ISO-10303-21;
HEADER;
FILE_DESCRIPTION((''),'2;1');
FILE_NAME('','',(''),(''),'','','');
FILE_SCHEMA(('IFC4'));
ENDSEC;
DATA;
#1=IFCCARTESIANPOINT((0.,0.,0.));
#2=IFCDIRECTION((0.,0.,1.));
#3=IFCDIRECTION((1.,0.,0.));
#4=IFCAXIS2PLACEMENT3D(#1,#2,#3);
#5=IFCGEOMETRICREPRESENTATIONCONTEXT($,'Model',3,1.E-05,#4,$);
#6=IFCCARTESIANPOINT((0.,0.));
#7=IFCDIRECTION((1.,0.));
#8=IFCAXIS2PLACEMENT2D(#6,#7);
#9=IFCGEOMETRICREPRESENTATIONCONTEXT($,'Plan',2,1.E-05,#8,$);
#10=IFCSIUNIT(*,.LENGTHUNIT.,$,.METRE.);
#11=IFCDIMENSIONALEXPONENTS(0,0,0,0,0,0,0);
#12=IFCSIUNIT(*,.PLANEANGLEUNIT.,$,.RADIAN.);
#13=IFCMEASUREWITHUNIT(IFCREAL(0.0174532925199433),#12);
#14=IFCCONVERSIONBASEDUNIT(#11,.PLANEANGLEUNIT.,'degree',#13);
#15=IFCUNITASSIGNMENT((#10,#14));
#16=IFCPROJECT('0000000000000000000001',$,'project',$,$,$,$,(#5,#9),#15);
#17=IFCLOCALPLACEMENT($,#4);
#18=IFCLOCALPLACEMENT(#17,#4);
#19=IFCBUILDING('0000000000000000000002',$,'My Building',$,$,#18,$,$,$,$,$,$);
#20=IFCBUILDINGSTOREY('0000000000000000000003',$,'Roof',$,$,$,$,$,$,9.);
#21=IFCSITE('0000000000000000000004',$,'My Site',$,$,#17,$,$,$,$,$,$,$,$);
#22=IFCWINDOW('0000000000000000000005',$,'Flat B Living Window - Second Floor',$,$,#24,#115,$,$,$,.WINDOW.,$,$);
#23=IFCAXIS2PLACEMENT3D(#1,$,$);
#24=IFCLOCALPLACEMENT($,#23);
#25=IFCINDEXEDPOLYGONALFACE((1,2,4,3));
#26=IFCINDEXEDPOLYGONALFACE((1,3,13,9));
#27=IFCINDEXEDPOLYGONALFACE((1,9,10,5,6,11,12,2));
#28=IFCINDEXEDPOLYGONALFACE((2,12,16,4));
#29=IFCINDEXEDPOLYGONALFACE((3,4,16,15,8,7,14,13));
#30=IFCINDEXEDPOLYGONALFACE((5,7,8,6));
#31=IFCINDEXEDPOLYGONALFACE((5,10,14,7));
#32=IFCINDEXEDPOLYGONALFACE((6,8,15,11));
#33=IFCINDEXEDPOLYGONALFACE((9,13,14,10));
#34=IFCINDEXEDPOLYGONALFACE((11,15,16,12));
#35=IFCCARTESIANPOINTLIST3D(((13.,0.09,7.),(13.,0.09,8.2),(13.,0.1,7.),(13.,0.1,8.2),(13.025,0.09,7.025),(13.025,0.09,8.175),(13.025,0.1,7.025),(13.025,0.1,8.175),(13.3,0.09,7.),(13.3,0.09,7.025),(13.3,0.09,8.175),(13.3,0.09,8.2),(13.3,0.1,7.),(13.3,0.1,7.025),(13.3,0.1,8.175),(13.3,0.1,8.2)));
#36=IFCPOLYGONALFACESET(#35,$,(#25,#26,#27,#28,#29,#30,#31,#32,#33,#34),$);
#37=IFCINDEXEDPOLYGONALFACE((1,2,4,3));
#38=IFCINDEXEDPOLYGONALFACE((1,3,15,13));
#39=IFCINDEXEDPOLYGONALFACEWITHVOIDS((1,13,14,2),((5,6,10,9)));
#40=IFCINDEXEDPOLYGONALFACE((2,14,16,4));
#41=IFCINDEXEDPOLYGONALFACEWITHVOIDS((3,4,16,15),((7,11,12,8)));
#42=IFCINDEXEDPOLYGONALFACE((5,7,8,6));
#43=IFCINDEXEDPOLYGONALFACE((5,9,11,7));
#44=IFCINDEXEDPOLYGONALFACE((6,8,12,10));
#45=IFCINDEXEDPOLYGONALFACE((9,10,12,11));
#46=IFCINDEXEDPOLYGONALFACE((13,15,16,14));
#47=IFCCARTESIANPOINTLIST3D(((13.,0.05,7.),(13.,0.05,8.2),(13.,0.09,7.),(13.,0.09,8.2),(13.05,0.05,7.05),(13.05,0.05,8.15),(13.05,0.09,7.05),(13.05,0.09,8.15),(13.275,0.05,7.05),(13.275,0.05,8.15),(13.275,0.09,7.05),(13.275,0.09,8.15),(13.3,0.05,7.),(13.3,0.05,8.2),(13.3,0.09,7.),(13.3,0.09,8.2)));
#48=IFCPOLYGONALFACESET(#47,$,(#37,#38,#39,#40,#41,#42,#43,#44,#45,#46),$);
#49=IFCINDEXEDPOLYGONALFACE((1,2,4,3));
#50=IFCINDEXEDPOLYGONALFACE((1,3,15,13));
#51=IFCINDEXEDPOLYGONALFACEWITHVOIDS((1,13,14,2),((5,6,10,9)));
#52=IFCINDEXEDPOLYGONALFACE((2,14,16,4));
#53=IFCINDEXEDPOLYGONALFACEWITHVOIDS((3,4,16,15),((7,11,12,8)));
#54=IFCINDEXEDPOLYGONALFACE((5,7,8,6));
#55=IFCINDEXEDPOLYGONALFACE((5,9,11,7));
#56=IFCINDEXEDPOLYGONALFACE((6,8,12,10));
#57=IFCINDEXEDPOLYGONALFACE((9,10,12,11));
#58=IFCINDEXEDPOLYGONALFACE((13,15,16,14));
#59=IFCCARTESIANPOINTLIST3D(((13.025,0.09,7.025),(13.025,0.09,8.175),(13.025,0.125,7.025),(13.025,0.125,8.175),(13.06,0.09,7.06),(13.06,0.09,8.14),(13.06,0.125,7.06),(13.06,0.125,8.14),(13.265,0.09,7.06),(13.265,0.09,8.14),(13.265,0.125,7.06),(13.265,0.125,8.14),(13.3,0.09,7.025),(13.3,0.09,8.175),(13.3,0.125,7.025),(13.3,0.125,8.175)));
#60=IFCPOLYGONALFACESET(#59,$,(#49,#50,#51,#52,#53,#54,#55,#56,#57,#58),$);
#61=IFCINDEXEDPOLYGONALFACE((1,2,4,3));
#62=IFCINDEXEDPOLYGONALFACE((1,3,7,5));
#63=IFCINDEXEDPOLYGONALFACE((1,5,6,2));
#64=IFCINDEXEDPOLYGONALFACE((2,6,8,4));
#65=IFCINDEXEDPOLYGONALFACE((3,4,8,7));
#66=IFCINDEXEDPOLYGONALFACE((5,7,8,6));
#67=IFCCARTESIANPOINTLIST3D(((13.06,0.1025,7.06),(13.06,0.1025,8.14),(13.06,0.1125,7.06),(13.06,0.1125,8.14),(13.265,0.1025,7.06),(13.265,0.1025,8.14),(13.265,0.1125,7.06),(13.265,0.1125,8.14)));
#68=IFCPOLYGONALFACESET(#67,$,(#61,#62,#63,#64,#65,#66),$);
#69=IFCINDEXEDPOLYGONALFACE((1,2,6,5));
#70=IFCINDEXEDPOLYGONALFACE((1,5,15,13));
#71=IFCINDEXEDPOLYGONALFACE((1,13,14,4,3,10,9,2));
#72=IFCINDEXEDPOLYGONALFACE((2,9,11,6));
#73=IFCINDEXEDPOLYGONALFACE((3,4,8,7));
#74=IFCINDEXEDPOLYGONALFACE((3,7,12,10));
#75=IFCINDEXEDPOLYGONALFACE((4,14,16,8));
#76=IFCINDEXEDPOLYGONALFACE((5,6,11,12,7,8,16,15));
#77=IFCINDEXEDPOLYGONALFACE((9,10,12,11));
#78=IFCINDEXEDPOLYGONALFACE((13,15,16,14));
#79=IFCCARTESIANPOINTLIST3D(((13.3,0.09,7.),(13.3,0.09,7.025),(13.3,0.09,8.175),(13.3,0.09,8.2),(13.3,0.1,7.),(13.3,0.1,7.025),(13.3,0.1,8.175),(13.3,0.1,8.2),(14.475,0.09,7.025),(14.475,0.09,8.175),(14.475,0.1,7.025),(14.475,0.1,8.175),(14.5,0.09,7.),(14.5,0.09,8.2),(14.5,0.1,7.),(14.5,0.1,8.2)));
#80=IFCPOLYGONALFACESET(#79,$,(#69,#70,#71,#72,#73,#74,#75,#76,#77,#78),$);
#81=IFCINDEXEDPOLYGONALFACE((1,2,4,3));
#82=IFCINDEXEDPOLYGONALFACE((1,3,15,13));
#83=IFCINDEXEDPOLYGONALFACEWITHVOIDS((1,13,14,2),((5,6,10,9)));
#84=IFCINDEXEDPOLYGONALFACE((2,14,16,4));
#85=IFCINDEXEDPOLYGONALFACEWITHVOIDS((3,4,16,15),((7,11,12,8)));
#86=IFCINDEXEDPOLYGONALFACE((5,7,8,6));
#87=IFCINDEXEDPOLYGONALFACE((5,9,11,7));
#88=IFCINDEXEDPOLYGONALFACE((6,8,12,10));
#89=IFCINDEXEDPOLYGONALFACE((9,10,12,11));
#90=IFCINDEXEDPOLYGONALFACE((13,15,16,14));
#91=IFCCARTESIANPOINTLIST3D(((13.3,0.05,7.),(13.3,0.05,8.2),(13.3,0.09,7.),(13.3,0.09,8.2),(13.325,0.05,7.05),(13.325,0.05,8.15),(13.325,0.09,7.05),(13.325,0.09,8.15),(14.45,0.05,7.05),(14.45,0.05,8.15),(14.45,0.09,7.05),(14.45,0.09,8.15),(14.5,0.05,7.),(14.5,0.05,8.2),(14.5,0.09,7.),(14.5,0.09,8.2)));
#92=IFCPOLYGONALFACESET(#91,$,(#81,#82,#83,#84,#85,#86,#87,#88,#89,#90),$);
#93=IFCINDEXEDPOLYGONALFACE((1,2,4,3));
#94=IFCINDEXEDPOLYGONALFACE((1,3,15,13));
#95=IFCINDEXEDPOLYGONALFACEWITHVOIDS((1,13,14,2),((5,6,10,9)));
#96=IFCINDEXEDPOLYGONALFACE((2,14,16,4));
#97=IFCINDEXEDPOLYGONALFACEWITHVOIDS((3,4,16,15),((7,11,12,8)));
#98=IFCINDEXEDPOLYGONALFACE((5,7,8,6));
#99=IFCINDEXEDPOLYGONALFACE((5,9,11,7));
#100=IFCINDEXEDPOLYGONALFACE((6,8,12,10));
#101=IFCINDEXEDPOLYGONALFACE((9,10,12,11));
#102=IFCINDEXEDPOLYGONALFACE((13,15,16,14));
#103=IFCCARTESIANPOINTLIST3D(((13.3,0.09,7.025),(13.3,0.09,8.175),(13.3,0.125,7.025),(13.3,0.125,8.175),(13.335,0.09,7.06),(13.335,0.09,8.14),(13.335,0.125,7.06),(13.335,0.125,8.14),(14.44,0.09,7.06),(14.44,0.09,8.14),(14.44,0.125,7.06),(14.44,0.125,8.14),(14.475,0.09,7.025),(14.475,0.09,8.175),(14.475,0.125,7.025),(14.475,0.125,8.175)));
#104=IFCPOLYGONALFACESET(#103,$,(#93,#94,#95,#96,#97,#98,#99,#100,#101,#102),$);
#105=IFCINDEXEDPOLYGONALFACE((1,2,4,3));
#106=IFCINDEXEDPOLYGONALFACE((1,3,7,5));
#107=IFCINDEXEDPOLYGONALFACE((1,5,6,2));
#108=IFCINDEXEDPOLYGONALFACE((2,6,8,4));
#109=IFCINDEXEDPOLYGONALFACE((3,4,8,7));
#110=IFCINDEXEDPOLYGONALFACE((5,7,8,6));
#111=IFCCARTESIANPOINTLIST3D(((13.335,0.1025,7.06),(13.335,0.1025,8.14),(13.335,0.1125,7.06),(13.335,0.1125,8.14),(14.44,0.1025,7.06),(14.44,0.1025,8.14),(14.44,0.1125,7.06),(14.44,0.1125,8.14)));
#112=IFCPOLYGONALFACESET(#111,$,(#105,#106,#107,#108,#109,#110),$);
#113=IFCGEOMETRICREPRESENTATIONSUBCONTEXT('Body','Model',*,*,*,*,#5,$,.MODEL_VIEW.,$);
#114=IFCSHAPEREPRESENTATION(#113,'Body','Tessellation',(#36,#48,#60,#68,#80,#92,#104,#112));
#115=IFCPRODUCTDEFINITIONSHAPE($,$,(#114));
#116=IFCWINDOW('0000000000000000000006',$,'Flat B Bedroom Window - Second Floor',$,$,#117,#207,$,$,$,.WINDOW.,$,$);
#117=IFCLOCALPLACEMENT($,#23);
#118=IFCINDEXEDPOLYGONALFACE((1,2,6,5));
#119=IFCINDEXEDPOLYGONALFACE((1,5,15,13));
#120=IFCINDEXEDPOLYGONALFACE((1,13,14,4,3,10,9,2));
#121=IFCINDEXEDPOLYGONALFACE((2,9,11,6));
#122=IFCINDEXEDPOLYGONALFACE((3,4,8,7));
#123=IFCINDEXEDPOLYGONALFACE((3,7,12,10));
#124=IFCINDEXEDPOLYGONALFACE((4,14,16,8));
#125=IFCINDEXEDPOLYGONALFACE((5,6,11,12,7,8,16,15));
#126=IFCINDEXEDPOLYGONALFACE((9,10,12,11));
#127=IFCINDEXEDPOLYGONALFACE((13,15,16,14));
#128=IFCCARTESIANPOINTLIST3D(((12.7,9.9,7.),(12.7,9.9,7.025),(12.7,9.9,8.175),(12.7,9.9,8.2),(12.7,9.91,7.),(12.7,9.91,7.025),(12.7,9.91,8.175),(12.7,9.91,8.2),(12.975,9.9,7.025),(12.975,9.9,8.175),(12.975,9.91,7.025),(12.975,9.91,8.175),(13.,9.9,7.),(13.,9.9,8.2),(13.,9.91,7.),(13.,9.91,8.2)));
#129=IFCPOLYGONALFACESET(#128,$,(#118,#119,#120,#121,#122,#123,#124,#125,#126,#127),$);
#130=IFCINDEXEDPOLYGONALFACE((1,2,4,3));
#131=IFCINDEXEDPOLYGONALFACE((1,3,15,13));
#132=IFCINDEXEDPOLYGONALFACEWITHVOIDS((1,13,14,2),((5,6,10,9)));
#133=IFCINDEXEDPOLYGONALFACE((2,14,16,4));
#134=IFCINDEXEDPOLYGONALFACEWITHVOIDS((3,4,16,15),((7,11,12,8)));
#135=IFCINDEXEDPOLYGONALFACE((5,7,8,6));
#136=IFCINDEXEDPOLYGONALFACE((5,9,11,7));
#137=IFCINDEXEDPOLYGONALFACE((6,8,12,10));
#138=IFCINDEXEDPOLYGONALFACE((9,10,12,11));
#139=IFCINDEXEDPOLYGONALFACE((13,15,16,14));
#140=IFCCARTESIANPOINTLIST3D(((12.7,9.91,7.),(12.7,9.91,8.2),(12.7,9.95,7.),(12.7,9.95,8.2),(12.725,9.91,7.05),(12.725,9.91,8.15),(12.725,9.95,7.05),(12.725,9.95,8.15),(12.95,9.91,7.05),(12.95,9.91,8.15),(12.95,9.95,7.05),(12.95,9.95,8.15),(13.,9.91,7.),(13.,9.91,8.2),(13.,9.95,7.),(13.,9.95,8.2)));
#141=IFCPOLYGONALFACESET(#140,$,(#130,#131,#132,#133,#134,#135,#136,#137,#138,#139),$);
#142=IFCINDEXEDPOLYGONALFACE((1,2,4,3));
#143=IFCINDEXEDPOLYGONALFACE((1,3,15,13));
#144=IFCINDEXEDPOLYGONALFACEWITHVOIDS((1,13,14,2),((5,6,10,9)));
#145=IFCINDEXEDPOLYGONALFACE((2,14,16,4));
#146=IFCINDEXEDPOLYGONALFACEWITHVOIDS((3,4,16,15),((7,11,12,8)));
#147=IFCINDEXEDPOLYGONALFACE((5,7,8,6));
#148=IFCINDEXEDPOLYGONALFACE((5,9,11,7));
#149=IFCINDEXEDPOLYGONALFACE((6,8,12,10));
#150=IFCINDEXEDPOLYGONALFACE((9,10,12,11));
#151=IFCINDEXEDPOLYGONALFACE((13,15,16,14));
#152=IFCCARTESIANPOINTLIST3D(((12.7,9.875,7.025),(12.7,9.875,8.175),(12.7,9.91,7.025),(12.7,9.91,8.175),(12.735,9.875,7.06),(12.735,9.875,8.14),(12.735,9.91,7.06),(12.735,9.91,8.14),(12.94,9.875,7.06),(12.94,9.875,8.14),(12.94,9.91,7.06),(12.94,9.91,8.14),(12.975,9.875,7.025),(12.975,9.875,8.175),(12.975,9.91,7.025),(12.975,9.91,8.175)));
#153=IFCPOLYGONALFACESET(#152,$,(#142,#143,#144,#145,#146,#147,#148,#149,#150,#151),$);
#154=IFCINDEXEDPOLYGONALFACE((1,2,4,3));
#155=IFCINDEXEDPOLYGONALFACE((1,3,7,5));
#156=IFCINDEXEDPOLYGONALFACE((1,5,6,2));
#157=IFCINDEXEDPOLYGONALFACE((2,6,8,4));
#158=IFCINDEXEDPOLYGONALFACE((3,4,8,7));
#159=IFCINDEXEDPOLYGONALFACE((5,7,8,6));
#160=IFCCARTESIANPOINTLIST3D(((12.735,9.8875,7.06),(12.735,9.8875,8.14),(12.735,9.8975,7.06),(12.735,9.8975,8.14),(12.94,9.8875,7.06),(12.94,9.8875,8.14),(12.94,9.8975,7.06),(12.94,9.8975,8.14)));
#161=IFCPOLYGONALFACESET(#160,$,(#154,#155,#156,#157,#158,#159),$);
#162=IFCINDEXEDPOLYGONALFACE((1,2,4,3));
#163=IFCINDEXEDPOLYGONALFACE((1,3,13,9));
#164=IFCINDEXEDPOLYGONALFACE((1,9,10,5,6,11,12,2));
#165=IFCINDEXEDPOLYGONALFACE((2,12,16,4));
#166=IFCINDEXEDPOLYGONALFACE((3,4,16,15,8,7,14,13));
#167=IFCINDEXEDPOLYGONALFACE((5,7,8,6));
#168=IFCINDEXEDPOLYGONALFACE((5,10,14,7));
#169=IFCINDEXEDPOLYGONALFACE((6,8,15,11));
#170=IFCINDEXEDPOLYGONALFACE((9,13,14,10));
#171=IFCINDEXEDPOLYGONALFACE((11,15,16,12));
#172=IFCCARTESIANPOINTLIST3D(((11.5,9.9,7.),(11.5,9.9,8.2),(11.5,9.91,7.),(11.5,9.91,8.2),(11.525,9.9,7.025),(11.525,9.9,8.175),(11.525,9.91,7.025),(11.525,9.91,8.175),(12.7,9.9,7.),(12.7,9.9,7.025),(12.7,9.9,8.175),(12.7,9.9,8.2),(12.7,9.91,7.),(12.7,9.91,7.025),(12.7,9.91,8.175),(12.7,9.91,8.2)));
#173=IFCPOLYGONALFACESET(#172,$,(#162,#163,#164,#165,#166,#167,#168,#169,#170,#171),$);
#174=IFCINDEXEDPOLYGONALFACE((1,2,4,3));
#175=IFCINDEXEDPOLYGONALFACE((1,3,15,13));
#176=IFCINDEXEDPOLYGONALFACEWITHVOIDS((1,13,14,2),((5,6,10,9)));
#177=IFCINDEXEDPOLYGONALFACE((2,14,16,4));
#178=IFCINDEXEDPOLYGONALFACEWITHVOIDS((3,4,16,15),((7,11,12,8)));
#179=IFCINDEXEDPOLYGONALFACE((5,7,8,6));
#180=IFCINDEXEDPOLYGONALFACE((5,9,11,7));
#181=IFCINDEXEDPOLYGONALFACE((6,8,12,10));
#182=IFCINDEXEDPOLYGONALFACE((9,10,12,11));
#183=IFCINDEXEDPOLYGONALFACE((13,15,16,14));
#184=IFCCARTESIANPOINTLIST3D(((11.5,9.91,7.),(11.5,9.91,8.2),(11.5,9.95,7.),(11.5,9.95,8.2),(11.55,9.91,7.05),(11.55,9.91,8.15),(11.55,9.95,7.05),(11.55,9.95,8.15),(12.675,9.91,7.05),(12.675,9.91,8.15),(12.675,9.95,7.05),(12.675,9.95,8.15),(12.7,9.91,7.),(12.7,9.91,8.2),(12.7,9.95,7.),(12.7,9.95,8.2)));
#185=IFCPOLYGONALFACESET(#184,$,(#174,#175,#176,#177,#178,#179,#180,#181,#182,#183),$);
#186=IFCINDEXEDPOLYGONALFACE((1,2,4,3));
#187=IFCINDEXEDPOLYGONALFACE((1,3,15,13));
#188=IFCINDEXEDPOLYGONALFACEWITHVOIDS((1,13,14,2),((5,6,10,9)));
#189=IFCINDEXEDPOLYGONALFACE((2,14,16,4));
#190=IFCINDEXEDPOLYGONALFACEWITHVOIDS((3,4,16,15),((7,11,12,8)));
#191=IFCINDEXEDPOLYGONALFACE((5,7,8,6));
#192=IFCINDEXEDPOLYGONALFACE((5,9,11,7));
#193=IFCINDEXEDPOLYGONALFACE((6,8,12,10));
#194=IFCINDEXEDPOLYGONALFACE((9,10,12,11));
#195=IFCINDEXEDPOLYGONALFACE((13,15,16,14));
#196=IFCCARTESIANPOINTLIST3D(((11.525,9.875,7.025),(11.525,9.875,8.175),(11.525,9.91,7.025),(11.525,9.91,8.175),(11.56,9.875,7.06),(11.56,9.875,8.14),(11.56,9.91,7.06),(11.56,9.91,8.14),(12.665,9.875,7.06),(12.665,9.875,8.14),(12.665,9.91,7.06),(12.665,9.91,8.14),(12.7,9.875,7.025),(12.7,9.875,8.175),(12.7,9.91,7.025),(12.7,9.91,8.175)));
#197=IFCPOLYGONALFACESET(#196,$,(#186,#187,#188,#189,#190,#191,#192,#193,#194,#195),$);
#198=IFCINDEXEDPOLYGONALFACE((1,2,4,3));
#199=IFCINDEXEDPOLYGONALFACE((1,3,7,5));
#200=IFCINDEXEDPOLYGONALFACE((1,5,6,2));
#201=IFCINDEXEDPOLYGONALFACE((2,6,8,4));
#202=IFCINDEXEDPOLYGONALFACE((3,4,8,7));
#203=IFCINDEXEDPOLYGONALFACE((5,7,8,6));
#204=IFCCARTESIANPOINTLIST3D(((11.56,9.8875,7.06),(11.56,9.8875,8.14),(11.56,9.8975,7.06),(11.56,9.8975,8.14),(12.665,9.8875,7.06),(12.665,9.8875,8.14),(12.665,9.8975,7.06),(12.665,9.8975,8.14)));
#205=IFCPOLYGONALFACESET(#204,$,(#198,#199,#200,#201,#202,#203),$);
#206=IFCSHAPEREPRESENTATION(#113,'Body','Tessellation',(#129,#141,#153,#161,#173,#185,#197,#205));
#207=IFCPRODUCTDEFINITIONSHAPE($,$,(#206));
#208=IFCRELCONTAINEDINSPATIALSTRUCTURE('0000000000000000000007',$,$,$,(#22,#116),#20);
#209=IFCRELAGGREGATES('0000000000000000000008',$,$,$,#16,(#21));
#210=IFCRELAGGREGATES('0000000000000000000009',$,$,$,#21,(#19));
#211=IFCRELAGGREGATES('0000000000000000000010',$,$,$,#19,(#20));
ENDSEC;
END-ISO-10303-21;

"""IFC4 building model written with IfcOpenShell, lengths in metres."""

from ifc_helpers import new_model, entity, si_unit, converted_unit, frame, origin_with_axes, origin_2d_with_axis, place, context, subcontext, project, spatial, line, indexed_curve, outline, extrude, element, save


model = new_model("IFC4")

# Units and contexts
model_context = context("Model", 3, precision=1e-05, world=origin_with_axes())
plan_context = context("Plan", 2, precision=1e-05, world=origin_2d_with_axis())
body_context = subcontext(model_context, "Body", "Model", "MODEL_VIEW")
ifc_project = project(units=[si_unit("LENGTHUNIT", "METRE"), converted_unit("PLANEANGLEUNIT", "degree", entity("IfcReal", 0.0174532925199433), si_unit("PLANEANGLEUNIT", "RADIAN"), dimensions=[0, 0, 0, 0, 0, 0, 0])], contexts=[model_context, plan_context])

# Site, building, storey
site_placement = place(None, origin_with_axes())
site = spatial("IfcSite", under=ifc_project, at=site_placement, Name="My Site")
building_placement = place(site_placement, origin_with_axes())
building = spatial("IfcBuilding", under=site, at=building_placement, Name="My Building")
storey = spatial("IfcBuildingStorey", under=building, Name="Roof", Elevation=9.0)

# Windows
window_1_placement = place(None, frame((13.0, 0.0, 7.0), z_axis=(0.0, 0.0, 1.0), x_axis=(1.0, 0.0, 0.0)))
element("IfcWindow", 1, at=window_1_placement, inside=storey, Name="Flat B Living Window - Second Floor", PredefinedType="WINDOW", context=body_context, shape_type="SweptSolid", body=[
    extrude(outline(indexed_curve([(0.3, 0.0), (0.0, 0.0), (0.0, 1.2), (0.3, 1.2), (0.3, 1.175), (0.025, 1.175), (0.025, 0.025), (0.3, 0.025)], segments=[line(1, 2, 3, 4, 5, 6, 7, 8, 1)])), frame((0.0, 0.09, 0.0), z_axis=(0.0, -1.0, 0.0), x_axis=(1.0, 0.0, 0.0)), (0.0, 0.0, -1.0), 0.01),
    extrude(outline(indexed_curve([(0.0, 0.0), (0.3, 0.0), (0.3, 1.2), (0.0, 1.2)], segments=[line(1, 2, 3, 4, 1)]), holes=[indexed_curve([(0.05, 0.05), (0.275, 0.05), (0.275, 1.15), (0.05, 1.15)], segments=[line(1, 2, 3, 4, 1)])]), frame((0.0, 0.05, 0.0), z_axis=(0.0, -1.0, 0.0), x_axis=(1.0, 0.0, 0.0)), (0.0, 0.0, -1.0), 0.04),
    extrude(outline(indexed_curve([(0.0, 0.0), (0.275, 0.0), (0.275, 1.15), (0.0, 1.15)], segments=[line(1, 2, 3, 4, 1)]), holes=[indexed_curve([(0.035, 0.035), (0.24, 0.035), (0.24, 1.115), (0.035, 1.115)], segments=[line(1, 2, 3, 4, 1)])]), frame((0.025, 0.09, 0.025), z_axis=(0.0, -1.0, 0.0), x_axis=(1.0, 0.0, 0.0)), (0.0, 0.0, -1.0), 0.035),
    extrude(outline(indexed_curve([(0.035, 0.035), (0.24, 0.035), (0.24, 1.115), (0.035, 1.115)], segments=[line(1, 2, 3, 4, 1)])), frame((0.025, 0.1025, 0.025), z_axis=(0.0, -1.0, 0.0), x_axis=(1.0, 0.0, 0.0)), (0.0, 0.0, -1.0), 0.01),
    extrude(outline(indexed_curve([(0.0, 1.2), (1.2, 1.2), (1.2, 0.0), (0.0, 0.0), (0.0, 0.025), (1.175, 0.025), (1.175, 1.175), (0.0, 1.175)], segments=[line(1, 2, 3, 4, 5, 6, 7, 8, 1)])), frame((0.3, 0.09, 0.0), z_axis=(0.0, -1.0, 0.0), x_axis=(1.0, 0.0, 0.0)), (0.0, 0.0, -1.0), 0.01),
    extrude(outline(indexed_curve([(0.0, 0.0), (1.2, 0.0), (1.2, 1.2), (0.0, 1.2)], segments=[line(1, 2, 3, 4, 1)]), holes=[indexed_curve([(0.025, 0.05), (1.15, 0.05), (1.15, 1.15), (0.025, 1.15)], segments=[line(1, 2, 3, 4, 1)])]), frame((0.3, 0.05, 0.0), z_axis=(0.0, -1.0, 0.0), x_axis=(1.0, 0.0, 0.0)), (0.0, 0.0, -1.0), 0.04),
    extrude(outline(indexed_curve([(0.0, 0.0), (1.175, 0.0), (1.175, 1.15), (0.0, 1.15)], segments=[line(1, 2, 3, 4, 1)]), holes=[indexed_curve([(0.035, 0.035), (1.14, 0.035), (1.14, 1.115), (0.035, 1.115)], segments=[line(1, 2, 3, 4, 1)])]), frame((0.3, 0.09, 0.025), z_axis=(0.0, -1.0, 0.0), x_axis=(1.0, 0.0, 0.0)), (0.0, 0.0, -1.0), 0.035),
    extrude(outline(indexed_curve([(0.035, 0.035), (1.14, 0.035), (1.14, 1.115), (0.035, 1.115)], segments=[line(1, 2, 3, 4, 1)])), frame((0.3, 0.1025, 0.025), z_axis=(0.0, -1.0, 0.0), x_axis=(1.0, 0.0, 0.0)), (0.0, 0.0, -1.0), 0.01),
])
window_2_placement = place(None, frame((13.0, 10.0, 7.0), z_axis=(0.0, 0.0, 1.0), x_axis=(-1.0, 0.0, 0.0)))
element("IfcWindow", 2, at=window_2_placement, inside=storey, Name="Flat B Bedroom Window - Second Floor", PredefinedType="WINDOW", context=body_context, shape_type="SweptSolid", body=[
    extrude(outline(indexed_curve([(0.3, 0.0), (0.0, 0.0), (0.0, 1.2), (0.3, 1.2), (0.3, 1.175), (0.025, 1.175), (0.025, 0.025), (0.3, 0.025)], segments=[line(1, 2, 3, 4, 5, 6, 7, 8, 1)])), frame((0.0, 0.09, 0.0), z_axis=(0.0, -1.0, 0.0), x_axis=(1.0, 0.0, 0.0)), (0.0, 0.0, -1.0), 0.01),
    extrude(outline(indexed_curve([(0.0, 0.0), (0.3, 0.0), (0.3, 1.2), (0.0, 1.2)], segments=[line(1, 2, 3, 4, 1)]), holes=[indexed_curve([(0.05, 0.05), (0.275, 0.05), (0.275, 1.15), (0.05, 1.15)], segments=[line(1, 2, 3, 4, 1)])]), frame((0.0, 0.05, 0.0), z_axis=(0.0, -1.0, 0.0), x_axis=(1.0, 0.0, 0.0)), (0.0, 0.0, -1.0), 0.04),
    extrude(outline(indexed_curve([(0.0, 0.0), (0.275, 0.0), (0.275, 1.15), (0.0, 1.15)], segments=[line(1, 2, 3, 4, 1)]), holes=[indexed_curve([(0.035, 0.035), (0.24, 0.035), (0.24, 1.115), (0.035, 1.115)], segments=[line(1, 2, 3, 4, 1)])]), frame((0.025, 0.09, 0.025), z_axis=(0.0, -1.0, 0.0), x_axis=(1.0, 0.0, 0.0)), (0.0, 0.0, -1.0), 0.035),
    extrude(outline(indexed_curve([(0.035, 0.035), (0.24, 0.035), (0.24, 1.115), (0.035, 1.115)], segments=[line(1, 2, 3, 4, 1)])), frame((0.025, 0.1025, 0.025), z_axis=(0.0, -1.0, 0.0), x_axis=(1.0, 0.0, 0.0)), (0.0, 0.0, -1.0), 0.01),
    extrude(outline(indexed_curve([(0.0, 1.2), (1.2, 1.2), (1.2, 0.0), (0.0, 0.0), (0.0, 0.025), (1.175, 0.025), (1.175, 1.175), (0.0, 1.175)], segments=[line(1, 2, 3, 4, 5, 6, 7, 8, 1)])), frame((0.3, 0.09, 0.0), z_axis=(0.0, -1.0, 0.0), x_axis=(1.0, 0.0, 0.0)), (0.0, 0.0, -1.0), 0.01),
    extrude(outline(indexed_curve([(0.0, 0.0), (1.2, 0.0), (1.2, 1.2), (0.0, 1.2)], segments=[line(1, 2, 3, 4, 1)]), holes=[indexed_curve([(0.025, 0.05), (1.15, 0.05), (1.15, 1.15), (0.025, 1.15)], segments=[line(1, 2, 3, 4, 1)])]), frame((0.3, 0.05, 0.0), z_axis=(0.0, -1.0, 0.0), x_axis=(1.0, 0.0, 0.0)), (0.0, 0.0, -1.0), 0.04),
    extrude(outline(indexed_curve([(0.0, 0.0), (1.175, 0.0), (1.175, 1.15), (0.0, 1.15)], segments=[line(1, 2, 3, 4, 1)]), holes=[indexed_curve([(0.035, 0.035), (1.14, 0.035), (1.14, 1.115), (0.035, 1.115)], segments=[line(1, 2, 3, 4, 1)])]), frame((0.3, 0.09, 0.025), z_axis=(0.0, -1.0, 0.0), x_axis=(1.0, 0.0, 0.0)), (0.0, 0.0, -1.0), 0.035),
    extrude(outline(indexed_curve([(0.035, 0.035), (1.14, 0.035), (1.14, 1.115), (0.035, 1.115)], segments=[line(1, 2, 3, 4, 1)])), frame((0.3, 0.1025, 0.025), z_axis=(0.0, -1.0, 0.0), x_axis=(1.0, 0.0, 0.0)), (0.0, 0.0, -1.0), 0.01),
])

save(model, "model.ifc")
